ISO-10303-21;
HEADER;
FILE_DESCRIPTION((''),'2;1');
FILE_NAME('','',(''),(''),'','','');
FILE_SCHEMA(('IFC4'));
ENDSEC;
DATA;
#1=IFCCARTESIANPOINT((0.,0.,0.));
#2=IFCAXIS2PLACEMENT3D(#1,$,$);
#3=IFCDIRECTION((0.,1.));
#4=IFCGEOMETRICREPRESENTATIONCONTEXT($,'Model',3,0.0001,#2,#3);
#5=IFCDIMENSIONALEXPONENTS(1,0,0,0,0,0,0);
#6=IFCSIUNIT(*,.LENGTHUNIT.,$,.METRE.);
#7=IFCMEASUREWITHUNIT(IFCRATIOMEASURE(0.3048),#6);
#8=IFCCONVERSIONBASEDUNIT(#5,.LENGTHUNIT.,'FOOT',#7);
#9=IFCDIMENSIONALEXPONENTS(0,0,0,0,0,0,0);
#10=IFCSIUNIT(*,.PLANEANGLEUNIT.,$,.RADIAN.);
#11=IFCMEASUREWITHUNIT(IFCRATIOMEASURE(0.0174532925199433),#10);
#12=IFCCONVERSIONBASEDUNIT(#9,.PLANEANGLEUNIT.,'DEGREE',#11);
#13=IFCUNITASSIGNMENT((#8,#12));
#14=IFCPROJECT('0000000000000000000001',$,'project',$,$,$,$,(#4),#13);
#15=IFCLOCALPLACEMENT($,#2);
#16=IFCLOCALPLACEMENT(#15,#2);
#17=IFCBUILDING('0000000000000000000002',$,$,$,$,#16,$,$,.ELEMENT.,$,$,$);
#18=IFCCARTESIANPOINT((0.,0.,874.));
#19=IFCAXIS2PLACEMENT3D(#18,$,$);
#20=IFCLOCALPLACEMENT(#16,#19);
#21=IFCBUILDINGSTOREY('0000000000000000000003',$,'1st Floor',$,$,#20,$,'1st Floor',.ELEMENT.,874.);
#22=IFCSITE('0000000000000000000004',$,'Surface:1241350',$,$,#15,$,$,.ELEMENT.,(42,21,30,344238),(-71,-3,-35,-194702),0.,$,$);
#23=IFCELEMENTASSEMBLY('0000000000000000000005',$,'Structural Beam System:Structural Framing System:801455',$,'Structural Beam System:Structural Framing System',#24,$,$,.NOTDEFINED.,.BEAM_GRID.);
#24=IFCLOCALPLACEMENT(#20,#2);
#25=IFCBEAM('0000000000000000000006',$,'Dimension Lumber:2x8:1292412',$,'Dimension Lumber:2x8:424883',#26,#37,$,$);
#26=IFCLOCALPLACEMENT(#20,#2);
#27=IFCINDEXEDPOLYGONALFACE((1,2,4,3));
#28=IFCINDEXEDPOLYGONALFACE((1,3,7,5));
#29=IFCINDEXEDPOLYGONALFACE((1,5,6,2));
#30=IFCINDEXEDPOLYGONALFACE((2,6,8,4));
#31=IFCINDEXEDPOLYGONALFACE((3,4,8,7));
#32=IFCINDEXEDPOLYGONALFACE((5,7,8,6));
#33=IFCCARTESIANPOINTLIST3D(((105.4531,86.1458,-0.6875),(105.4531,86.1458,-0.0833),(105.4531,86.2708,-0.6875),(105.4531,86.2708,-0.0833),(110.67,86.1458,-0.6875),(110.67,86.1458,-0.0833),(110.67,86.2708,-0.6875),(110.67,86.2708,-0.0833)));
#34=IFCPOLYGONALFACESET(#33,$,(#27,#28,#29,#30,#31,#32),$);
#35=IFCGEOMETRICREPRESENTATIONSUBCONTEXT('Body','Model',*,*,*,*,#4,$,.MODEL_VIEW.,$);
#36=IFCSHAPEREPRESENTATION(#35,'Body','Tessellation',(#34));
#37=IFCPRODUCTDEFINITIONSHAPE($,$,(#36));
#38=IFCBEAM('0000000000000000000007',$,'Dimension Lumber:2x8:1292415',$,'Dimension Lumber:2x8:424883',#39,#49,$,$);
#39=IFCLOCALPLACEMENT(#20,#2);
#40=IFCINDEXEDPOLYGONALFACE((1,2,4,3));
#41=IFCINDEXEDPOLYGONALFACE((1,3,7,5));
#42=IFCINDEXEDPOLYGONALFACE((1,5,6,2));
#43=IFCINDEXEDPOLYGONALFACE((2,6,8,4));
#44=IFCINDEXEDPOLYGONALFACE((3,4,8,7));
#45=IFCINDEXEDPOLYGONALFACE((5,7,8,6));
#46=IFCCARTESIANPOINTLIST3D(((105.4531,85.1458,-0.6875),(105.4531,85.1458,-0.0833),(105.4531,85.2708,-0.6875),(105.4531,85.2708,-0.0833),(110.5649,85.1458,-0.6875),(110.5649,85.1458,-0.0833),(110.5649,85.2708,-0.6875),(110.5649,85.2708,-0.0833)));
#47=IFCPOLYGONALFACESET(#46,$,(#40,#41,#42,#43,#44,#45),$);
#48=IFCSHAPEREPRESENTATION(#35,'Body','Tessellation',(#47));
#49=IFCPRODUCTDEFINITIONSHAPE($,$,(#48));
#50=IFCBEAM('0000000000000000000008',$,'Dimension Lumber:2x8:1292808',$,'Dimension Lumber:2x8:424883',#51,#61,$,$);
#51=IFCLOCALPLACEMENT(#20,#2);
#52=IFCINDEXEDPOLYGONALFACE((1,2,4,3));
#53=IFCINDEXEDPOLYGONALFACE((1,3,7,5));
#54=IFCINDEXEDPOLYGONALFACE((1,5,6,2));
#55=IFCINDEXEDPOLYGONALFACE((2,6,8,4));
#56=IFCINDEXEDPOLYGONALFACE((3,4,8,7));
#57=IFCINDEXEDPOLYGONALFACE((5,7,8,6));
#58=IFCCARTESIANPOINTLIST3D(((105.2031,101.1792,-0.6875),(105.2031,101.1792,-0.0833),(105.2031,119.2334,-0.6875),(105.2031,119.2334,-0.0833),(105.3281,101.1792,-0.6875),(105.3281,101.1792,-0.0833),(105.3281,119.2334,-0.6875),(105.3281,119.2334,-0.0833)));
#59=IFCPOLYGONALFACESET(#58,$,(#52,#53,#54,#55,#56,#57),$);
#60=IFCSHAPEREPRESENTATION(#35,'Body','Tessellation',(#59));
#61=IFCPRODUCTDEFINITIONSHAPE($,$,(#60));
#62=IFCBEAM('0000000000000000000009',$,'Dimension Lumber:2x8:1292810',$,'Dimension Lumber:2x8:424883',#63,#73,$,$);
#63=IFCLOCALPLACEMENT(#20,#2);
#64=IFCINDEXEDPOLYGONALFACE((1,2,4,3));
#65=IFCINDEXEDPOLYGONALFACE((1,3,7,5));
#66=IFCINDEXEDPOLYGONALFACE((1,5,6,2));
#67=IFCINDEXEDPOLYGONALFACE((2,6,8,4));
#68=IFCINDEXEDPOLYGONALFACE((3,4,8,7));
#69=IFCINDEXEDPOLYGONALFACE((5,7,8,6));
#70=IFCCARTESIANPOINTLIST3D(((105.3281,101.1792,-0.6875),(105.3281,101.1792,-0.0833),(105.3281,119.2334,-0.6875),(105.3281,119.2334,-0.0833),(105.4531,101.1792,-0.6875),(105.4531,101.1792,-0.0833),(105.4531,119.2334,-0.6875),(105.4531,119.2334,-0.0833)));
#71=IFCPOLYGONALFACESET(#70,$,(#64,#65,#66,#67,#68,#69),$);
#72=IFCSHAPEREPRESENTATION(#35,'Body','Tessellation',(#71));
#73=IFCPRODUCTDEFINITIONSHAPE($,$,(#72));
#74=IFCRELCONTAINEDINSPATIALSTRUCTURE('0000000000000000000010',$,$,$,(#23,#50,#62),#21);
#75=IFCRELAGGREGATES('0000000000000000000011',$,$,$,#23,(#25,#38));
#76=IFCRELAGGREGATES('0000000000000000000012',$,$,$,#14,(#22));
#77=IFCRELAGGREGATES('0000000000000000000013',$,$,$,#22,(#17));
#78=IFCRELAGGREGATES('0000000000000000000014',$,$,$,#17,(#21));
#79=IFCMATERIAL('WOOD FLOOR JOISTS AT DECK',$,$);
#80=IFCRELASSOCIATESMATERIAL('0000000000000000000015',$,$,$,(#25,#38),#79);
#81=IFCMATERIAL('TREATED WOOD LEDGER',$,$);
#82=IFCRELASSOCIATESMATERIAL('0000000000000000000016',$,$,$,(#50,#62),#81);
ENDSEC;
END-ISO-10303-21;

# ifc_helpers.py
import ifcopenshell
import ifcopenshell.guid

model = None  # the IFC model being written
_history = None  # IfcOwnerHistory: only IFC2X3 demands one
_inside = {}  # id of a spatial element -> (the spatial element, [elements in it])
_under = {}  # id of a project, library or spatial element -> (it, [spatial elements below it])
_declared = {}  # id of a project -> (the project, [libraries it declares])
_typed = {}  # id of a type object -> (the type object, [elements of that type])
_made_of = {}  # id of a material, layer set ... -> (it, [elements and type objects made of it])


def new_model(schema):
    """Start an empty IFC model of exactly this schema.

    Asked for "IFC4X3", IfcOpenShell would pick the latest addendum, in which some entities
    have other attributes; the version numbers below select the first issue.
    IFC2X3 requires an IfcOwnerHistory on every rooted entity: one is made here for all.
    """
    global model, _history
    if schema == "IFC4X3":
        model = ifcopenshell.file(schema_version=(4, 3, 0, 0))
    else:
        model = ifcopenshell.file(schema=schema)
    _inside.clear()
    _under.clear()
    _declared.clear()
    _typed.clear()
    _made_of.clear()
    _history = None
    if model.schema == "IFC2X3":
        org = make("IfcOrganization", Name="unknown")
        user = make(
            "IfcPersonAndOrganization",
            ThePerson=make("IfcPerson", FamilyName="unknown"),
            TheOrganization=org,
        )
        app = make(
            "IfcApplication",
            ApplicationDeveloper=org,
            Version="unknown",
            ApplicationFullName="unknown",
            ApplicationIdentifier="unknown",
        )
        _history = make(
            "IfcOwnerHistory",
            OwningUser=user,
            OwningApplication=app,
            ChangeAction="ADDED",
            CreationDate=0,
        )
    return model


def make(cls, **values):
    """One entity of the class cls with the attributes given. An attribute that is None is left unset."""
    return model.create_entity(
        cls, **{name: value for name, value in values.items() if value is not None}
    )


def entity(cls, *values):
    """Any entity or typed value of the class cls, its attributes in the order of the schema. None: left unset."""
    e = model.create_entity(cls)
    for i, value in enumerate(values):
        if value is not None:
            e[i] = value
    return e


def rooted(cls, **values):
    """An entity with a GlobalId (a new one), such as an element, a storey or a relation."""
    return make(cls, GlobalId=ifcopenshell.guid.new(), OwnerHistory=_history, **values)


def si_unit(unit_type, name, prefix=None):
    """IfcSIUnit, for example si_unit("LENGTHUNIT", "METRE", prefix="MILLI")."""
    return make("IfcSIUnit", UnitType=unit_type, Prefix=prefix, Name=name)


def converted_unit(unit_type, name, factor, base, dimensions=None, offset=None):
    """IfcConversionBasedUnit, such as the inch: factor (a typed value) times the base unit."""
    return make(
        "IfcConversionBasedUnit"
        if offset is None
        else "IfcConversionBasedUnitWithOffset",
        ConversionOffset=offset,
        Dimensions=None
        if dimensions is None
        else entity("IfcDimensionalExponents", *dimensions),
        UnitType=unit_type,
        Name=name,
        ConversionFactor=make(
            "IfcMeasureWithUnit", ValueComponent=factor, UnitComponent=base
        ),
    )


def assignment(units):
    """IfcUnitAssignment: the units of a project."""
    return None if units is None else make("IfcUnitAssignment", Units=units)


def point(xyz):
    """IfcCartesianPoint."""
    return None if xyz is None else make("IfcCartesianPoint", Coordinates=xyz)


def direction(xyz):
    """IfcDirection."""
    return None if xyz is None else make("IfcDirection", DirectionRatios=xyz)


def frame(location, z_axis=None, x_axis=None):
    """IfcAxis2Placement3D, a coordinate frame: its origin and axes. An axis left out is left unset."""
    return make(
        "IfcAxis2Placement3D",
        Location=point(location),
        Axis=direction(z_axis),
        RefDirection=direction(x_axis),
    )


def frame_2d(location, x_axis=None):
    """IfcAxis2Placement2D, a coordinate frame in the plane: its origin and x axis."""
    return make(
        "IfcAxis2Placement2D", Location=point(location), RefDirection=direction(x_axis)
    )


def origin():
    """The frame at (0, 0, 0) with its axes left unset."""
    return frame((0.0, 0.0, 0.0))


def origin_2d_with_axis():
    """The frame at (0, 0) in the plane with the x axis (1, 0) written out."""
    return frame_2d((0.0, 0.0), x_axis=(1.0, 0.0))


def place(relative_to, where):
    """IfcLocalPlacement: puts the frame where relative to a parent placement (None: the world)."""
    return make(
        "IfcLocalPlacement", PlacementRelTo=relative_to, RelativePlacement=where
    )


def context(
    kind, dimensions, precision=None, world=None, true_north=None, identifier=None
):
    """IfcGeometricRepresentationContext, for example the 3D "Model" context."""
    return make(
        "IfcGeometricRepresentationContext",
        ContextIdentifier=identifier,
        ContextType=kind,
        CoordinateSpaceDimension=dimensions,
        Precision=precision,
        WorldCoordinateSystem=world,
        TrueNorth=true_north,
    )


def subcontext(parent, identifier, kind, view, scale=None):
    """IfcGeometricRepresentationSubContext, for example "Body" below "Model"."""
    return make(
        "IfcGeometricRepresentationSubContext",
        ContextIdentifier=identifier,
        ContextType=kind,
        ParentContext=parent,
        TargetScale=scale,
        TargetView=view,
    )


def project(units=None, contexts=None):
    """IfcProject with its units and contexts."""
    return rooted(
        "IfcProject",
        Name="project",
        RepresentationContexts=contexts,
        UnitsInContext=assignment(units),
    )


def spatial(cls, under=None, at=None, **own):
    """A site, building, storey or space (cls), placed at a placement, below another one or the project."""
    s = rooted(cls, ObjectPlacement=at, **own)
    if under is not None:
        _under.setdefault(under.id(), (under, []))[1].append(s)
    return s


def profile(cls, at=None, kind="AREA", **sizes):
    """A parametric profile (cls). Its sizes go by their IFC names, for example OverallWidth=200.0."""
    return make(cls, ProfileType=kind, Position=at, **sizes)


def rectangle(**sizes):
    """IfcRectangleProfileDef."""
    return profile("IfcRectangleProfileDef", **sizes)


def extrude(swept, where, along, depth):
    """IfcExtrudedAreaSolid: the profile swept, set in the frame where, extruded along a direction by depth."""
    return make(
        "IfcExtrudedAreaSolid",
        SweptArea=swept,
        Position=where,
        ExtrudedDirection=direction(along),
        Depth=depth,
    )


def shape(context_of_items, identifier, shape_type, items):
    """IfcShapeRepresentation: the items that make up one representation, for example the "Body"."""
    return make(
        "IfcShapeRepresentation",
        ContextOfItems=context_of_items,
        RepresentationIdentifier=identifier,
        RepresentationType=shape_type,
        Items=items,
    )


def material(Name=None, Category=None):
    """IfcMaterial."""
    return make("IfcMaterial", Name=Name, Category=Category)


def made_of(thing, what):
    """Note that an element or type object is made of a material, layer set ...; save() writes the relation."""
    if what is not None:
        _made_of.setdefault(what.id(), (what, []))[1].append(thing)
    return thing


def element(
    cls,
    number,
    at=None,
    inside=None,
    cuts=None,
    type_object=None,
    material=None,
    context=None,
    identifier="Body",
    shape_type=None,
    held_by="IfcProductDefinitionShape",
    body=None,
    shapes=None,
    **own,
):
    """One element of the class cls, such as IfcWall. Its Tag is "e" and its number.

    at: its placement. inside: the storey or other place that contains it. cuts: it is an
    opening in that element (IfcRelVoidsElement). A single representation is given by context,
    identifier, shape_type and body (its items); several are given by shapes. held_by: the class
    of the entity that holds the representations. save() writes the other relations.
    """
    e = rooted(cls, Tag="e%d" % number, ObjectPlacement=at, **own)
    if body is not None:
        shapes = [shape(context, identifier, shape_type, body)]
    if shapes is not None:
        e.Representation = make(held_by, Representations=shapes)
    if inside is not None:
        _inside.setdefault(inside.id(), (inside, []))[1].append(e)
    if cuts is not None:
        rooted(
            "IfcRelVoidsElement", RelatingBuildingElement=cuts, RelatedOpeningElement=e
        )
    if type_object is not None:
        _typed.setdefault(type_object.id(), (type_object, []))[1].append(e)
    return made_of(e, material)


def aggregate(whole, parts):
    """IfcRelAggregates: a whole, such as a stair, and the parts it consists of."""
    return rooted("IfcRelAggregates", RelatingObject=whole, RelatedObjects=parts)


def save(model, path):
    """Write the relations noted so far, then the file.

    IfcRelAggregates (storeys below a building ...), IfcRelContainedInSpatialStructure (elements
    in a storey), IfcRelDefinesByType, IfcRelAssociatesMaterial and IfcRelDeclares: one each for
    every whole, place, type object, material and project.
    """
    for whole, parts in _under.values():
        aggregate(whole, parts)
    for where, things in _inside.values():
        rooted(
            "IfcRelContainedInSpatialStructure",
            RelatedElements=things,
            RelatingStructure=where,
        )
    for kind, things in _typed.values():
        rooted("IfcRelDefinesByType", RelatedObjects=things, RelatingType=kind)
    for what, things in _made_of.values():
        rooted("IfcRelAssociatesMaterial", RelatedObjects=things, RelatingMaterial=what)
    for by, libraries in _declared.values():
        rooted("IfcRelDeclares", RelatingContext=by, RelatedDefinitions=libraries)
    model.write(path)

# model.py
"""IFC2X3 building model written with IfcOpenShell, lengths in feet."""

from ifc_helpers import new_model, entity, si_unit, converted_unit, direction, frame, frame_2d, origin, origin_2d_with_axis, place, context, subcontext, project, spatial, rectangle, extrude, material, element, aggregate, save


model = new_model("IFC2X3")

# Units and contexts
model_context = context("Model", 3, precision=0.0001, world=origin(), true_north=direction((0.0, 1.0)))
body_context = subcontext(model_context, "Body", "Model", "MODEL_VIEW")
ifc_project = project(units=[converted_unit("LENGTHUNIT", "FOOT", entity("IfcRatioMeasure", 0.3048), si_unit("LENGTHUNIT", "METRE"), dimensions=[1, 0, 0, 0, 0, 0, 0]), converted_unit("PLANEANGLEUNIT", "DEGREE", entity("IfcRatioMeasure", 0.0174532925199433), si_unit("PLANEANGLEUNIT", "RADIAN"), dimensions=[0, 0, 0, 0, 0, 0, 0])], contexts=[model_context])

# Site, building, storey
site_placement = place(None, origin())
site = spatial("IfcSite", under=ifc_project, at=site_placement, Name="Surface:1241350", CompositionType="ELEMENT", RefLatitude=(42, 21, 30, 344238), RefLongitude=(-71, -3, -35, -194702), RefElevation=0.0)
building_placement = place(site_placement, origin())
building = spatial("IfcBuilding", under=site, at=building_placement, CompositionType="ELEMENT")
storey_placement = place(building_placement, frame((0.0, 0.0, 874.0)))
storey = spatial("IfcBuildingStorey", under=building, at=storey_placement, Name="1st Floor", LongName="1st Floor", CompositionType="ELEMENT", Elevation=874.0)

# Element assembly, beams
assembly_placement = place(storey_placement, origin())
assembly = element("IfcElementAssembly", 1, at=assembly_placement, inside=storey, Name="Structural Beam System:Structural Framing System:801455", ObjectType="Structural Beam System:Structural Framing System", AssemblyPlace="NOTDEFINED", PredefinedType="BEAM_GRID")
ifc_material_1 = material(Name="WOOD FLOOR JOISTS AT DECK")
beam_1_placement = place(assembly_placement, frame((105.3906, 86.2083, 0.0)))
beam_1 = element("IfcBeam", 2, at=beam_1_placement, material=ifc_material_1, Name="Dimension Lumber:2x8:1292412", ObjectType="Dimension Lumber:2x8:424883", context=body_context, shape_type="SweptSolid", body=[
    extrude(rectangle(XDim=0.6042, YDim=0.125, at=origin_2d_with_axis()), frame((0.0625, 0.0, -0.3854), z_axis=(1.0, 0.0, 0.0), x_axis=(0.0, 0.0, -1.0)), (0.0, 0.0, 1.0), 5.2169),
])
beam_2_placement = place(assembly_placement, frame((105.3906, 85.2083, 0.0)))
beam_2 = element("IfcBeam", 3, at=beam_2_placement, material=ifc_material_1, Name="Dimension Lumber:2x8:1292415", ObjectType="Dimension Lumber:2x8:424883", context=body_context, shape_type="SweptSolid", body=[
    extrude(rectangle(XDim=0.6042, YDim=0.125, at=origin_2d_with_axis()), frame((0.0625, 0.0, -0.3854), z_axis=(1.0, 0.0, 0.0), x_axis=(0.0, 0.0, -1.0)), (0.0, 0.0, 1.0), 5.1118),
])
aggregate(assembly, [beam_1, beam_2])

# Beams
ifc_material_2 = material(Name="TREATED WOOD LEDGER")
beam_3_placement = place(storey_placement, frame((105.2656, 101.1792, 0.0), z_axis=(0.0, 0.0, 1.0), x_axis=(0.0, 1.0, 0.0)))
element("IfcBeam", 4, at=beam_3_placement, inside=storey, material=ifc_material_2, Name="Dimension Lumber:2x8:1292808", ObjectType="Dimension Lumber:2x8:424883", context=body_context, shape_type="SweptSolid", body=[
    extrude(rectangle(XDim=0.6042, YDim=0.125, at=frame_2d((0.0, 0.0), x_axis=(1.0, 0.0))), frame((0.0, 0.0, -0.3854), z_axis=(1.0, 0.0, 0.0), x_axis=(0.0, 0.0, -1.0)), (0.0, 0.0, 1.0), 18.0542),
])
beam_4_placement = place(storey_placement, frame((105.3906, 101.1792, 0.0), z_axis=(0.0, 0.0, 1.0), x_axis=(0.0, 1.0, 0.0)))
element("IfcBeam", 5, at=beam_4_placement, inside=storey, material=ifc_material_2, Name="Dimension Lumber:2x8:1292810", ObjectType="Dimension Lumber:2x8:424883", context=body_context, shape_type="SweptSolid", body=[
    extrude(rectangle(XDim=0.6042, YDim=0.125, at=frame_2d((0.0, 0.0), x_axis=(1.0, 0.0))), frame((0.0, 0.0, -0.3854), z_axis=(1.0, 0.0, 0.0), x_axis=(0.0, 0.0, -1.0)), (0.0, 0.0, 1.0), 18.0542),
])

save(model, "model.ifc")
